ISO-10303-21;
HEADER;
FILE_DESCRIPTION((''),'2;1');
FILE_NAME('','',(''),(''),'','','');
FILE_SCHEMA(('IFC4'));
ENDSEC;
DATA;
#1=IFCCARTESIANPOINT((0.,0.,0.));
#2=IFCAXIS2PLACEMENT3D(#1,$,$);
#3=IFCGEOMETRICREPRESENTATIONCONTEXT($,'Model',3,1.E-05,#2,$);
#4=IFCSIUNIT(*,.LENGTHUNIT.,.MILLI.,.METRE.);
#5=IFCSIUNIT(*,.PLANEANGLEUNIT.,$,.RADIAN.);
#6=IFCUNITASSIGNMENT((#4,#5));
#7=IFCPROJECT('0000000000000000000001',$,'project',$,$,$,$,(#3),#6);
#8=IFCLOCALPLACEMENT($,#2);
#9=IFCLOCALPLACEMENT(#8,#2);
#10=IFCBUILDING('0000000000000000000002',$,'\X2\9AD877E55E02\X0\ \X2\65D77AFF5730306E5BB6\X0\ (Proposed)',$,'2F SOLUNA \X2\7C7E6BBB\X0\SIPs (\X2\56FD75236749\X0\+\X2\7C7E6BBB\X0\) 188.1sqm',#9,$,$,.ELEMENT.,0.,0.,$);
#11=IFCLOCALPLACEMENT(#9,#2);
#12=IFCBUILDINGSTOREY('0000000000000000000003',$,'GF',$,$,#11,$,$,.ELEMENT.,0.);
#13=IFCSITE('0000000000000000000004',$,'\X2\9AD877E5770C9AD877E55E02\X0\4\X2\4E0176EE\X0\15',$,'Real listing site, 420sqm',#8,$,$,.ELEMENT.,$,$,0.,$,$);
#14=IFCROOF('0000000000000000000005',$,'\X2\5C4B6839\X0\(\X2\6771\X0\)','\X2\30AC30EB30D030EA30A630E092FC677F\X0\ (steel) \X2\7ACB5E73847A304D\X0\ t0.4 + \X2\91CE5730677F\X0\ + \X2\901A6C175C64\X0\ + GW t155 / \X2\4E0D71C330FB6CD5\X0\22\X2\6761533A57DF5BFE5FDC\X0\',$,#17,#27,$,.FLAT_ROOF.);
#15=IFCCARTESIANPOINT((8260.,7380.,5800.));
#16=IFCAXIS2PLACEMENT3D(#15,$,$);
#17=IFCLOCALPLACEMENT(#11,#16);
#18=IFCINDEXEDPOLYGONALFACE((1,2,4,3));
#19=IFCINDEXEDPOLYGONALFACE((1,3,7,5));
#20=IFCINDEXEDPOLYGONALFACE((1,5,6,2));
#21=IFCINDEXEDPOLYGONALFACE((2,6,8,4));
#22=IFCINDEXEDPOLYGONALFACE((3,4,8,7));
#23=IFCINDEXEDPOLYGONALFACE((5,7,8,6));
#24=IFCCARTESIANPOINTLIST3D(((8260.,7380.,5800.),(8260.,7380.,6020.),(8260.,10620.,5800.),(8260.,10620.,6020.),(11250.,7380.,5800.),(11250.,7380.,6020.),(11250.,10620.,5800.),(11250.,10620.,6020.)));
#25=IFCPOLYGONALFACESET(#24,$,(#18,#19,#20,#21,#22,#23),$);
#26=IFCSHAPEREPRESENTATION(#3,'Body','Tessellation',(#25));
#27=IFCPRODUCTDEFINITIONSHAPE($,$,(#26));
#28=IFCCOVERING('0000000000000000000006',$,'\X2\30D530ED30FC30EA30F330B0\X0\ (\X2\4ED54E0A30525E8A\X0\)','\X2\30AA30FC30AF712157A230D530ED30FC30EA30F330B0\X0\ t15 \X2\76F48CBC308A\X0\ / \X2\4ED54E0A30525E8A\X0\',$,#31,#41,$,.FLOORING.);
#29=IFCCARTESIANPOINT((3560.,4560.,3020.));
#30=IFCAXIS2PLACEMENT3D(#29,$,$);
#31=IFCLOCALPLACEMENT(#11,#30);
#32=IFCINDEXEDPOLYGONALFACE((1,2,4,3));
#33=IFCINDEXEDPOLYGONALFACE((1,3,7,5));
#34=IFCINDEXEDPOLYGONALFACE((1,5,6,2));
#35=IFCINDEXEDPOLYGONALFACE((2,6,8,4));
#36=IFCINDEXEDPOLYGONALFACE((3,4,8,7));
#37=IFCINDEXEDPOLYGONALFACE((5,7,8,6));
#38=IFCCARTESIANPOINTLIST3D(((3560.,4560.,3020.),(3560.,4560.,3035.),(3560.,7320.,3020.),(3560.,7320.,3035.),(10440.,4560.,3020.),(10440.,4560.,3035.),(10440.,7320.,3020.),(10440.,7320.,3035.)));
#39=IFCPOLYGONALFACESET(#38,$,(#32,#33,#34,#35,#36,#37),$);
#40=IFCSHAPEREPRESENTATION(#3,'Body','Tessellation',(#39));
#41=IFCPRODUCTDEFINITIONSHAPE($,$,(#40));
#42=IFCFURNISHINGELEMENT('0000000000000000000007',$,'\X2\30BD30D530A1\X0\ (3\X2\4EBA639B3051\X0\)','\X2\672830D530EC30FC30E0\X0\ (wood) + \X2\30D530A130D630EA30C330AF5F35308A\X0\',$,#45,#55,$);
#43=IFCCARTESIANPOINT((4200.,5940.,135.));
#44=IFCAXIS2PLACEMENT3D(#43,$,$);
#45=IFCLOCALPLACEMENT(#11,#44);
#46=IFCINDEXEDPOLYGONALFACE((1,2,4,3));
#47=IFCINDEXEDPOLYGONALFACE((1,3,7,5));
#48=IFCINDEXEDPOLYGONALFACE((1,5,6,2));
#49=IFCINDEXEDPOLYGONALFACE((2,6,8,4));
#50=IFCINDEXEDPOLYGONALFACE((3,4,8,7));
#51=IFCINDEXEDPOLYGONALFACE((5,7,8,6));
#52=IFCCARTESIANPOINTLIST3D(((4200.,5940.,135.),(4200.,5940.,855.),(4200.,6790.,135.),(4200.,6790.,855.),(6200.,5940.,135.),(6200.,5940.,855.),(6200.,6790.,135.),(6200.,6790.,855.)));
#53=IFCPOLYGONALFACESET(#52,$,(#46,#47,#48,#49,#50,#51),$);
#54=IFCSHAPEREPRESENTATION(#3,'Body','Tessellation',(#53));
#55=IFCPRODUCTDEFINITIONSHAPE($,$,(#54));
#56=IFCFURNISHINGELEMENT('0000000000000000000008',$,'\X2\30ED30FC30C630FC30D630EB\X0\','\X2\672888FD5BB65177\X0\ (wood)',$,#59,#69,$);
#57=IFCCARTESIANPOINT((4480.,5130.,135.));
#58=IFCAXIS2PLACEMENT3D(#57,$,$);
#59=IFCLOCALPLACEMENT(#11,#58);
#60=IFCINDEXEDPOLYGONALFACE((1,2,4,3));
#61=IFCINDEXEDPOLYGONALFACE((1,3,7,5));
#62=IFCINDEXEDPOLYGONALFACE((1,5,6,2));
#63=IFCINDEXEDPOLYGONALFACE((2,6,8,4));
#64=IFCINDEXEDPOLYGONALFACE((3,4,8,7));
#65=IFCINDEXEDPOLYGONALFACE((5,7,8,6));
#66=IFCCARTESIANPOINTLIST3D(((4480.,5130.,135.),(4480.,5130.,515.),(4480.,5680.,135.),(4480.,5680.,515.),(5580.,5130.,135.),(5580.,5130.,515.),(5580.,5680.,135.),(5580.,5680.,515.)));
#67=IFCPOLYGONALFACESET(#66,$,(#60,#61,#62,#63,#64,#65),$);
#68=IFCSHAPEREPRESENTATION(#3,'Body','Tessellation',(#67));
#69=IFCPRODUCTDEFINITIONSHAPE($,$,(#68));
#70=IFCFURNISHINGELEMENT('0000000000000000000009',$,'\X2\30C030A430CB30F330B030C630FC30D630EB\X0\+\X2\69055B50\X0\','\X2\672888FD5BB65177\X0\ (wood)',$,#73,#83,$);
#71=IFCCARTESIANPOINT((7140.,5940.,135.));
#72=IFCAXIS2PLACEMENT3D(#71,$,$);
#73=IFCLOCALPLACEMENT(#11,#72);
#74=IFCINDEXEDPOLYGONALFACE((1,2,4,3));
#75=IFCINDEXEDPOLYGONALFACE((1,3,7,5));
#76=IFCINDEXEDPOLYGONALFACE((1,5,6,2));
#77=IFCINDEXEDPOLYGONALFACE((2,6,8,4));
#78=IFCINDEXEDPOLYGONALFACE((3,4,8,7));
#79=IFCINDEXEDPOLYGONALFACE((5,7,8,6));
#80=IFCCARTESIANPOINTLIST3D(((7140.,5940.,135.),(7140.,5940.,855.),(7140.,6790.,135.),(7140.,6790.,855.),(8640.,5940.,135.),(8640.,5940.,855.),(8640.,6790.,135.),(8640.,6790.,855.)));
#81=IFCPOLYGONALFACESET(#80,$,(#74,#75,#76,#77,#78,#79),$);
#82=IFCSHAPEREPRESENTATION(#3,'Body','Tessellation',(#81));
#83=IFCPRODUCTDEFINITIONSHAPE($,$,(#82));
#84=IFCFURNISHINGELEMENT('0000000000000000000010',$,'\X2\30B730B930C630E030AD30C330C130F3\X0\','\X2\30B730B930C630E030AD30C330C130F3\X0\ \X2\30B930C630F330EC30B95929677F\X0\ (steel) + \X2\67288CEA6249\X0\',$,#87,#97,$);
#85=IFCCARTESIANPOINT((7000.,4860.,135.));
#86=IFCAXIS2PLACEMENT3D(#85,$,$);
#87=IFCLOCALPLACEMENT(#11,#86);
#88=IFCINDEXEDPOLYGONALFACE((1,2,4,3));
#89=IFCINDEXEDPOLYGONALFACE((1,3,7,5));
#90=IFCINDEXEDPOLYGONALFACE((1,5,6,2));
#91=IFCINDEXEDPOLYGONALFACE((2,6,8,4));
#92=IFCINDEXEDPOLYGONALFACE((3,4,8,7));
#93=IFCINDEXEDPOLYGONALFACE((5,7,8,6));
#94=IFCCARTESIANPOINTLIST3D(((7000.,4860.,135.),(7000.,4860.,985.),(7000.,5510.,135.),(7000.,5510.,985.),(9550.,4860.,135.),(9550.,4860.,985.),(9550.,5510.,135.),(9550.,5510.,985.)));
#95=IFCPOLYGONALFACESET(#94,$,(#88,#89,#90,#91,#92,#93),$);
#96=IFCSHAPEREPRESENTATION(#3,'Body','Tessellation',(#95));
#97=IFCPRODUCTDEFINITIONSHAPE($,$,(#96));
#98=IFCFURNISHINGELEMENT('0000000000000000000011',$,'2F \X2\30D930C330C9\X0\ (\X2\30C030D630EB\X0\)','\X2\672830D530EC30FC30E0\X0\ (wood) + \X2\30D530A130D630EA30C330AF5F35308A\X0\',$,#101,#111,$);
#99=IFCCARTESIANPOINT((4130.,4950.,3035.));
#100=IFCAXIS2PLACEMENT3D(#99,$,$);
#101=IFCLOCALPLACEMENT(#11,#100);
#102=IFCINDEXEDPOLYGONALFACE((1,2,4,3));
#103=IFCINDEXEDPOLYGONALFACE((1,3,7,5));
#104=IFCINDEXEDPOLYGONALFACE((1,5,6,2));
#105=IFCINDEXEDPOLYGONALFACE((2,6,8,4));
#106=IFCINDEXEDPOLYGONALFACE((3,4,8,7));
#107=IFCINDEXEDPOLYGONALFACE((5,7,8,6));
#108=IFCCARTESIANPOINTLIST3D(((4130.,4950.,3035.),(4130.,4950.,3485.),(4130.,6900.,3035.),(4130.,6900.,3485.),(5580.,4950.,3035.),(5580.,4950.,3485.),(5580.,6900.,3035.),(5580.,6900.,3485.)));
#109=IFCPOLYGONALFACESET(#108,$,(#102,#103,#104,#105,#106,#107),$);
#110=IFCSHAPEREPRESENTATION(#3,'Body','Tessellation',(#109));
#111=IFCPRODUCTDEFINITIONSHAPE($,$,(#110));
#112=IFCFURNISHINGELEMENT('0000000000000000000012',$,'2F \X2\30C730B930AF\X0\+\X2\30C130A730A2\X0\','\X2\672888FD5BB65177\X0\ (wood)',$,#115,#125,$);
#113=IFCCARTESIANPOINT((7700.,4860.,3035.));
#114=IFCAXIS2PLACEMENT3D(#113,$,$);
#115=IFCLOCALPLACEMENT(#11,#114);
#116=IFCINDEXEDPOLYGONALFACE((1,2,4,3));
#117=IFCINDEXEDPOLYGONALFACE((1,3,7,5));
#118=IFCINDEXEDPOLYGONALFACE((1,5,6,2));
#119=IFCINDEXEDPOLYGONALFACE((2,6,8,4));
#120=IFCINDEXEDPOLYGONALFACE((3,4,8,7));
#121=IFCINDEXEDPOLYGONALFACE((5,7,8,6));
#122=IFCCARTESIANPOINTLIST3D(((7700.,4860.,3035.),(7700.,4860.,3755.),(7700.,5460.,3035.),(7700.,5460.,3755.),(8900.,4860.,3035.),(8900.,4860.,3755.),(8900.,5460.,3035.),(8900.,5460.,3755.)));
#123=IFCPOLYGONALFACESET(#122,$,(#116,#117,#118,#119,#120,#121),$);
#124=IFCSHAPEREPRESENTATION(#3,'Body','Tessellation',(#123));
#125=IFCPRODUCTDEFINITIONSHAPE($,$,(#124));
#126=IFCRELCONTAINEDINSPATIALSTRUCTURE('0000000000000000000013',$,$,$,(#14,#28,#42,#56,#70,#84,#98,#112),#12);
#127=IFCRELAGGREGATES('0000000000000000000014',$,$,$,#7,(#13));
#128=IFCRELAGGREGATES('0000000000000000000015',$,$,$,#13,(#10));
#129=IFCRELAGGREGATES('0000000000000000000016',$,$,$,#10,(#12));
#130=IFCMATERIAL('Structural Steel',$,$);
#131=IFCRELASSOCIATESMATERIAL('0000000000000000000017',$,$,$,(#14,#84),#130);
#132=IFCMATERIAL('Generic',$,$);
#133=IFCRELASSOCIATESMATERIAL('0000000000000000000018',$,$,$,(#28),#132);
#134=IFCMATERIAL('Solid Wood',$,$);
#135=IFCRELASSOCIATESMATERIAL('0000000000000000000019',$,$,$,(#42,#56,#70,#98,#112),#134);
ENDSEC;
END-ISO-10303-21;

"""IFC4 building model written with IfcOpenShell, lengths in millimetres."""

from ifc_helpers import new_model, si_unit, frame, frame_2d, origin, place, context, project, spatial, rectangle, extrude, material, element, save


model = new_model("IFC4")

# Units and contexts
model_context = context("Model", 3, precision=1e-05, world=origin())
ifc_project = project(units=[si_unit("LENGTHUNIT", "METRE", prefix="MILLI"), si_unit("PLANEANGLEUNIT", "RADIAN")], contexts=[model_context])

# Site, building, storey
site_placement = place(None, origin())
site = spatial("IfcSite", under=ifc_project, at=site_placement, Name="高知県高知市4丁目15", ObjectType="Real listing site, 420sqm", CompositionType="ELEMENT", RefElevation=0.0)
building_placement = place(site_placement, origin())
building = spatial("IfcBuilding", under=site, at=building_placement, Name="高知市 旗竿地の家 (Proposed)", ObjectType="2F SOLUNA 籾殻SIPs (国産杉+籾殻) 188.1sqm", CompositionType="ELEMENT", ElevationOfRefHeight=0.0, ElevationOfTerrain=0.0)
storey_placement = place(building_placement, origin())
storey = spatial("IfcBuildingStorey", under=building, at=storey_placement, Name="GF", CompositionType="ELEMENT", Elevation=0.0)

# Shared definitions
ifc_material_1 = material(Name="Solid Wood")

# Shared definitions
ifc_material_2 = material(Name="Generic")

# Roof
ifc_material_3 = material(Name="Structural Steel")
roof_placement = place(storey_placement, frame((8260.0, 7380.0, 5800.0)))
element("IfcRoof", 1, at=roof_placement, inside=storey, material=ifc_material_3, Name="屋根(東)", Description="ガルバリウム鋼板 (steel) 立平葺き t0.4 + 野地板 + 通気層 + GW t155 / 不燃・法22条区域対応", PredefinedType="FLAT_ROOF", context=model_context, shape_type="SweptSolid", body=[
    extrude(rectangle(XDim=2990.0, YDim=3240.0, at=frame_2d((1495.0, 1620.0))), frame((8260.0, 7380.0, 5800.0)), (0.0, 0.0, 1.0), 220.0),
])

# Covering
covering_placement = place(storey_placement, frame((3560.0, 4560.0, 3020.0)))
element("IfcCovering", 2, at=covering_placement, inside=storey, material=ifc_material_2, Name="フローリング (仕上げ床)", Description="オーク無垢フローリング t15 直貼り / 仕上げ床", PredefinedType="FLOORING", context=model_context, shape_type="SweptSolid", body=[
    extrude(rectangle(XDim=6880.0, YDim=2760.0, at=frame_2d((3440.0, 1380.0))), frame((3560.0, 4560.0, 3020.0)), (0.0, 0.0, 1.0), 15.0),
])

# Furnishing elements
furnishing_1_placement = place(storey_placement, frame((4200.0, 5940.0, 135.0)))
element("IfcFurnishingElement", 3, at=furnishing_1_placement, inside=storey, material=ifc_material_1, Name="ソファ (3人掛け)", Description="木フレーム (wood) + ファブリック張り", context=model_context, shape_type="SweptSolid", body=[
    extrude(rectangle(XDim=2000.0, YDim=850.0, at=frame_2d((1000.0, 425.0))), frame((4200.0, 5940.0, 135.0)), (0.0, 0.0, 1.0), 720.0),
])
furnishing_2_placement = place(storey_placement, frame((4480.0, 5130.0, 135.0)))
element("IfcFurnishingElement", 4, at=furnishing_2_placement, inside=storey, material=ifc_material_1, Name="ローテーブル", Description="木製家具 (wood)", context=model_context, shape_type="SweptSolid", body=[
    extrude(rectangle(XDim=1100.0, YDim=550.0, at=frame_2d((550.0, 275.0))), frame((4480.0, 5130.0, 135.0)), (0.0, 0.0, 1.0), 380.0),
])
furnishing_3_placement = place(storey_placement, frame((7140.0, 5940.0, 135.0)))
element("IfcFurnishingElement", 5, at=furnishing_3_placement, inside=storey, material=ifc_material_1, Name="ダイニングテーブル+椅子", Description="木製家具 (wood)", context=model_context, shape_type="SweptSolid", body=[
    extrude(rectangle(XDim=1500.0, YDim=850.0, at=frame_2d((750.0, 425.0))), frame((7140.0, 5940.0, 135.0)), (0.0, 0.0, 1.0), 720.0),
])
furnishing_4_placement = place(storey_placement, frame((7000.0, 4860.0, 135.0)))
element("IfcFurnishingElement", 6, at=furnishing_4_placement, inside=storey, material=ifc_material_3, Name="システムキッチン", Description="システムキッチン ステンレス天板 (steel) + 木質扉", context=model_context, shape_type="SweptSolid", body=[
    extrude(rectangle(XDim=2550.0, YDim=650.0, at=frame_2d((1275.0, 325.0))), frame((7000.0, 4860.0, 135.0)), (0.0, 0.0, 1.0), 850.0),
])
furnishing_5_placement = place(storey_placement, frame((4130.0, 4950.0, 3035.0)))
element("IfcFurnishingElement", 7, at=furnishing_5_placement, inside=storey, material=ifc_material_1, Name="2F ベッド (ダブル)", Description="木フレーム (wood) + ファブリック張り", context=model_context, shape_type="SweptSolid", body=[
    extrude(rectangle(XDim=1450.0, YDim=1950.0, at=frame_2d((725.0, 975.0))), frame((4130.0, 4950.0, 3035.0)), (0.0, 0.0, 1.0), 450.0),
])
furnishing_6_placement = place(storey_placement, frame((7700.0, 4860.0, 3035.0)))
element("IfcFurnishingElement", 8, at=furnishing_6_placement, inside=storey, material=ifc_material_1, Name="2F デスク+チェア", Description="木製家具 (wood)", context=model_context, shape_type="SweptSolid", body=[
    extrude(rectangle(XDim=1200.0, YDim=600.0, at=frame_2d((600.0, 300.0))), frame((7700.0, 4860.0, 3035.0)), (0.0, 0.0, 1.0), 720.0),
])

save(model, "model.ifc")
